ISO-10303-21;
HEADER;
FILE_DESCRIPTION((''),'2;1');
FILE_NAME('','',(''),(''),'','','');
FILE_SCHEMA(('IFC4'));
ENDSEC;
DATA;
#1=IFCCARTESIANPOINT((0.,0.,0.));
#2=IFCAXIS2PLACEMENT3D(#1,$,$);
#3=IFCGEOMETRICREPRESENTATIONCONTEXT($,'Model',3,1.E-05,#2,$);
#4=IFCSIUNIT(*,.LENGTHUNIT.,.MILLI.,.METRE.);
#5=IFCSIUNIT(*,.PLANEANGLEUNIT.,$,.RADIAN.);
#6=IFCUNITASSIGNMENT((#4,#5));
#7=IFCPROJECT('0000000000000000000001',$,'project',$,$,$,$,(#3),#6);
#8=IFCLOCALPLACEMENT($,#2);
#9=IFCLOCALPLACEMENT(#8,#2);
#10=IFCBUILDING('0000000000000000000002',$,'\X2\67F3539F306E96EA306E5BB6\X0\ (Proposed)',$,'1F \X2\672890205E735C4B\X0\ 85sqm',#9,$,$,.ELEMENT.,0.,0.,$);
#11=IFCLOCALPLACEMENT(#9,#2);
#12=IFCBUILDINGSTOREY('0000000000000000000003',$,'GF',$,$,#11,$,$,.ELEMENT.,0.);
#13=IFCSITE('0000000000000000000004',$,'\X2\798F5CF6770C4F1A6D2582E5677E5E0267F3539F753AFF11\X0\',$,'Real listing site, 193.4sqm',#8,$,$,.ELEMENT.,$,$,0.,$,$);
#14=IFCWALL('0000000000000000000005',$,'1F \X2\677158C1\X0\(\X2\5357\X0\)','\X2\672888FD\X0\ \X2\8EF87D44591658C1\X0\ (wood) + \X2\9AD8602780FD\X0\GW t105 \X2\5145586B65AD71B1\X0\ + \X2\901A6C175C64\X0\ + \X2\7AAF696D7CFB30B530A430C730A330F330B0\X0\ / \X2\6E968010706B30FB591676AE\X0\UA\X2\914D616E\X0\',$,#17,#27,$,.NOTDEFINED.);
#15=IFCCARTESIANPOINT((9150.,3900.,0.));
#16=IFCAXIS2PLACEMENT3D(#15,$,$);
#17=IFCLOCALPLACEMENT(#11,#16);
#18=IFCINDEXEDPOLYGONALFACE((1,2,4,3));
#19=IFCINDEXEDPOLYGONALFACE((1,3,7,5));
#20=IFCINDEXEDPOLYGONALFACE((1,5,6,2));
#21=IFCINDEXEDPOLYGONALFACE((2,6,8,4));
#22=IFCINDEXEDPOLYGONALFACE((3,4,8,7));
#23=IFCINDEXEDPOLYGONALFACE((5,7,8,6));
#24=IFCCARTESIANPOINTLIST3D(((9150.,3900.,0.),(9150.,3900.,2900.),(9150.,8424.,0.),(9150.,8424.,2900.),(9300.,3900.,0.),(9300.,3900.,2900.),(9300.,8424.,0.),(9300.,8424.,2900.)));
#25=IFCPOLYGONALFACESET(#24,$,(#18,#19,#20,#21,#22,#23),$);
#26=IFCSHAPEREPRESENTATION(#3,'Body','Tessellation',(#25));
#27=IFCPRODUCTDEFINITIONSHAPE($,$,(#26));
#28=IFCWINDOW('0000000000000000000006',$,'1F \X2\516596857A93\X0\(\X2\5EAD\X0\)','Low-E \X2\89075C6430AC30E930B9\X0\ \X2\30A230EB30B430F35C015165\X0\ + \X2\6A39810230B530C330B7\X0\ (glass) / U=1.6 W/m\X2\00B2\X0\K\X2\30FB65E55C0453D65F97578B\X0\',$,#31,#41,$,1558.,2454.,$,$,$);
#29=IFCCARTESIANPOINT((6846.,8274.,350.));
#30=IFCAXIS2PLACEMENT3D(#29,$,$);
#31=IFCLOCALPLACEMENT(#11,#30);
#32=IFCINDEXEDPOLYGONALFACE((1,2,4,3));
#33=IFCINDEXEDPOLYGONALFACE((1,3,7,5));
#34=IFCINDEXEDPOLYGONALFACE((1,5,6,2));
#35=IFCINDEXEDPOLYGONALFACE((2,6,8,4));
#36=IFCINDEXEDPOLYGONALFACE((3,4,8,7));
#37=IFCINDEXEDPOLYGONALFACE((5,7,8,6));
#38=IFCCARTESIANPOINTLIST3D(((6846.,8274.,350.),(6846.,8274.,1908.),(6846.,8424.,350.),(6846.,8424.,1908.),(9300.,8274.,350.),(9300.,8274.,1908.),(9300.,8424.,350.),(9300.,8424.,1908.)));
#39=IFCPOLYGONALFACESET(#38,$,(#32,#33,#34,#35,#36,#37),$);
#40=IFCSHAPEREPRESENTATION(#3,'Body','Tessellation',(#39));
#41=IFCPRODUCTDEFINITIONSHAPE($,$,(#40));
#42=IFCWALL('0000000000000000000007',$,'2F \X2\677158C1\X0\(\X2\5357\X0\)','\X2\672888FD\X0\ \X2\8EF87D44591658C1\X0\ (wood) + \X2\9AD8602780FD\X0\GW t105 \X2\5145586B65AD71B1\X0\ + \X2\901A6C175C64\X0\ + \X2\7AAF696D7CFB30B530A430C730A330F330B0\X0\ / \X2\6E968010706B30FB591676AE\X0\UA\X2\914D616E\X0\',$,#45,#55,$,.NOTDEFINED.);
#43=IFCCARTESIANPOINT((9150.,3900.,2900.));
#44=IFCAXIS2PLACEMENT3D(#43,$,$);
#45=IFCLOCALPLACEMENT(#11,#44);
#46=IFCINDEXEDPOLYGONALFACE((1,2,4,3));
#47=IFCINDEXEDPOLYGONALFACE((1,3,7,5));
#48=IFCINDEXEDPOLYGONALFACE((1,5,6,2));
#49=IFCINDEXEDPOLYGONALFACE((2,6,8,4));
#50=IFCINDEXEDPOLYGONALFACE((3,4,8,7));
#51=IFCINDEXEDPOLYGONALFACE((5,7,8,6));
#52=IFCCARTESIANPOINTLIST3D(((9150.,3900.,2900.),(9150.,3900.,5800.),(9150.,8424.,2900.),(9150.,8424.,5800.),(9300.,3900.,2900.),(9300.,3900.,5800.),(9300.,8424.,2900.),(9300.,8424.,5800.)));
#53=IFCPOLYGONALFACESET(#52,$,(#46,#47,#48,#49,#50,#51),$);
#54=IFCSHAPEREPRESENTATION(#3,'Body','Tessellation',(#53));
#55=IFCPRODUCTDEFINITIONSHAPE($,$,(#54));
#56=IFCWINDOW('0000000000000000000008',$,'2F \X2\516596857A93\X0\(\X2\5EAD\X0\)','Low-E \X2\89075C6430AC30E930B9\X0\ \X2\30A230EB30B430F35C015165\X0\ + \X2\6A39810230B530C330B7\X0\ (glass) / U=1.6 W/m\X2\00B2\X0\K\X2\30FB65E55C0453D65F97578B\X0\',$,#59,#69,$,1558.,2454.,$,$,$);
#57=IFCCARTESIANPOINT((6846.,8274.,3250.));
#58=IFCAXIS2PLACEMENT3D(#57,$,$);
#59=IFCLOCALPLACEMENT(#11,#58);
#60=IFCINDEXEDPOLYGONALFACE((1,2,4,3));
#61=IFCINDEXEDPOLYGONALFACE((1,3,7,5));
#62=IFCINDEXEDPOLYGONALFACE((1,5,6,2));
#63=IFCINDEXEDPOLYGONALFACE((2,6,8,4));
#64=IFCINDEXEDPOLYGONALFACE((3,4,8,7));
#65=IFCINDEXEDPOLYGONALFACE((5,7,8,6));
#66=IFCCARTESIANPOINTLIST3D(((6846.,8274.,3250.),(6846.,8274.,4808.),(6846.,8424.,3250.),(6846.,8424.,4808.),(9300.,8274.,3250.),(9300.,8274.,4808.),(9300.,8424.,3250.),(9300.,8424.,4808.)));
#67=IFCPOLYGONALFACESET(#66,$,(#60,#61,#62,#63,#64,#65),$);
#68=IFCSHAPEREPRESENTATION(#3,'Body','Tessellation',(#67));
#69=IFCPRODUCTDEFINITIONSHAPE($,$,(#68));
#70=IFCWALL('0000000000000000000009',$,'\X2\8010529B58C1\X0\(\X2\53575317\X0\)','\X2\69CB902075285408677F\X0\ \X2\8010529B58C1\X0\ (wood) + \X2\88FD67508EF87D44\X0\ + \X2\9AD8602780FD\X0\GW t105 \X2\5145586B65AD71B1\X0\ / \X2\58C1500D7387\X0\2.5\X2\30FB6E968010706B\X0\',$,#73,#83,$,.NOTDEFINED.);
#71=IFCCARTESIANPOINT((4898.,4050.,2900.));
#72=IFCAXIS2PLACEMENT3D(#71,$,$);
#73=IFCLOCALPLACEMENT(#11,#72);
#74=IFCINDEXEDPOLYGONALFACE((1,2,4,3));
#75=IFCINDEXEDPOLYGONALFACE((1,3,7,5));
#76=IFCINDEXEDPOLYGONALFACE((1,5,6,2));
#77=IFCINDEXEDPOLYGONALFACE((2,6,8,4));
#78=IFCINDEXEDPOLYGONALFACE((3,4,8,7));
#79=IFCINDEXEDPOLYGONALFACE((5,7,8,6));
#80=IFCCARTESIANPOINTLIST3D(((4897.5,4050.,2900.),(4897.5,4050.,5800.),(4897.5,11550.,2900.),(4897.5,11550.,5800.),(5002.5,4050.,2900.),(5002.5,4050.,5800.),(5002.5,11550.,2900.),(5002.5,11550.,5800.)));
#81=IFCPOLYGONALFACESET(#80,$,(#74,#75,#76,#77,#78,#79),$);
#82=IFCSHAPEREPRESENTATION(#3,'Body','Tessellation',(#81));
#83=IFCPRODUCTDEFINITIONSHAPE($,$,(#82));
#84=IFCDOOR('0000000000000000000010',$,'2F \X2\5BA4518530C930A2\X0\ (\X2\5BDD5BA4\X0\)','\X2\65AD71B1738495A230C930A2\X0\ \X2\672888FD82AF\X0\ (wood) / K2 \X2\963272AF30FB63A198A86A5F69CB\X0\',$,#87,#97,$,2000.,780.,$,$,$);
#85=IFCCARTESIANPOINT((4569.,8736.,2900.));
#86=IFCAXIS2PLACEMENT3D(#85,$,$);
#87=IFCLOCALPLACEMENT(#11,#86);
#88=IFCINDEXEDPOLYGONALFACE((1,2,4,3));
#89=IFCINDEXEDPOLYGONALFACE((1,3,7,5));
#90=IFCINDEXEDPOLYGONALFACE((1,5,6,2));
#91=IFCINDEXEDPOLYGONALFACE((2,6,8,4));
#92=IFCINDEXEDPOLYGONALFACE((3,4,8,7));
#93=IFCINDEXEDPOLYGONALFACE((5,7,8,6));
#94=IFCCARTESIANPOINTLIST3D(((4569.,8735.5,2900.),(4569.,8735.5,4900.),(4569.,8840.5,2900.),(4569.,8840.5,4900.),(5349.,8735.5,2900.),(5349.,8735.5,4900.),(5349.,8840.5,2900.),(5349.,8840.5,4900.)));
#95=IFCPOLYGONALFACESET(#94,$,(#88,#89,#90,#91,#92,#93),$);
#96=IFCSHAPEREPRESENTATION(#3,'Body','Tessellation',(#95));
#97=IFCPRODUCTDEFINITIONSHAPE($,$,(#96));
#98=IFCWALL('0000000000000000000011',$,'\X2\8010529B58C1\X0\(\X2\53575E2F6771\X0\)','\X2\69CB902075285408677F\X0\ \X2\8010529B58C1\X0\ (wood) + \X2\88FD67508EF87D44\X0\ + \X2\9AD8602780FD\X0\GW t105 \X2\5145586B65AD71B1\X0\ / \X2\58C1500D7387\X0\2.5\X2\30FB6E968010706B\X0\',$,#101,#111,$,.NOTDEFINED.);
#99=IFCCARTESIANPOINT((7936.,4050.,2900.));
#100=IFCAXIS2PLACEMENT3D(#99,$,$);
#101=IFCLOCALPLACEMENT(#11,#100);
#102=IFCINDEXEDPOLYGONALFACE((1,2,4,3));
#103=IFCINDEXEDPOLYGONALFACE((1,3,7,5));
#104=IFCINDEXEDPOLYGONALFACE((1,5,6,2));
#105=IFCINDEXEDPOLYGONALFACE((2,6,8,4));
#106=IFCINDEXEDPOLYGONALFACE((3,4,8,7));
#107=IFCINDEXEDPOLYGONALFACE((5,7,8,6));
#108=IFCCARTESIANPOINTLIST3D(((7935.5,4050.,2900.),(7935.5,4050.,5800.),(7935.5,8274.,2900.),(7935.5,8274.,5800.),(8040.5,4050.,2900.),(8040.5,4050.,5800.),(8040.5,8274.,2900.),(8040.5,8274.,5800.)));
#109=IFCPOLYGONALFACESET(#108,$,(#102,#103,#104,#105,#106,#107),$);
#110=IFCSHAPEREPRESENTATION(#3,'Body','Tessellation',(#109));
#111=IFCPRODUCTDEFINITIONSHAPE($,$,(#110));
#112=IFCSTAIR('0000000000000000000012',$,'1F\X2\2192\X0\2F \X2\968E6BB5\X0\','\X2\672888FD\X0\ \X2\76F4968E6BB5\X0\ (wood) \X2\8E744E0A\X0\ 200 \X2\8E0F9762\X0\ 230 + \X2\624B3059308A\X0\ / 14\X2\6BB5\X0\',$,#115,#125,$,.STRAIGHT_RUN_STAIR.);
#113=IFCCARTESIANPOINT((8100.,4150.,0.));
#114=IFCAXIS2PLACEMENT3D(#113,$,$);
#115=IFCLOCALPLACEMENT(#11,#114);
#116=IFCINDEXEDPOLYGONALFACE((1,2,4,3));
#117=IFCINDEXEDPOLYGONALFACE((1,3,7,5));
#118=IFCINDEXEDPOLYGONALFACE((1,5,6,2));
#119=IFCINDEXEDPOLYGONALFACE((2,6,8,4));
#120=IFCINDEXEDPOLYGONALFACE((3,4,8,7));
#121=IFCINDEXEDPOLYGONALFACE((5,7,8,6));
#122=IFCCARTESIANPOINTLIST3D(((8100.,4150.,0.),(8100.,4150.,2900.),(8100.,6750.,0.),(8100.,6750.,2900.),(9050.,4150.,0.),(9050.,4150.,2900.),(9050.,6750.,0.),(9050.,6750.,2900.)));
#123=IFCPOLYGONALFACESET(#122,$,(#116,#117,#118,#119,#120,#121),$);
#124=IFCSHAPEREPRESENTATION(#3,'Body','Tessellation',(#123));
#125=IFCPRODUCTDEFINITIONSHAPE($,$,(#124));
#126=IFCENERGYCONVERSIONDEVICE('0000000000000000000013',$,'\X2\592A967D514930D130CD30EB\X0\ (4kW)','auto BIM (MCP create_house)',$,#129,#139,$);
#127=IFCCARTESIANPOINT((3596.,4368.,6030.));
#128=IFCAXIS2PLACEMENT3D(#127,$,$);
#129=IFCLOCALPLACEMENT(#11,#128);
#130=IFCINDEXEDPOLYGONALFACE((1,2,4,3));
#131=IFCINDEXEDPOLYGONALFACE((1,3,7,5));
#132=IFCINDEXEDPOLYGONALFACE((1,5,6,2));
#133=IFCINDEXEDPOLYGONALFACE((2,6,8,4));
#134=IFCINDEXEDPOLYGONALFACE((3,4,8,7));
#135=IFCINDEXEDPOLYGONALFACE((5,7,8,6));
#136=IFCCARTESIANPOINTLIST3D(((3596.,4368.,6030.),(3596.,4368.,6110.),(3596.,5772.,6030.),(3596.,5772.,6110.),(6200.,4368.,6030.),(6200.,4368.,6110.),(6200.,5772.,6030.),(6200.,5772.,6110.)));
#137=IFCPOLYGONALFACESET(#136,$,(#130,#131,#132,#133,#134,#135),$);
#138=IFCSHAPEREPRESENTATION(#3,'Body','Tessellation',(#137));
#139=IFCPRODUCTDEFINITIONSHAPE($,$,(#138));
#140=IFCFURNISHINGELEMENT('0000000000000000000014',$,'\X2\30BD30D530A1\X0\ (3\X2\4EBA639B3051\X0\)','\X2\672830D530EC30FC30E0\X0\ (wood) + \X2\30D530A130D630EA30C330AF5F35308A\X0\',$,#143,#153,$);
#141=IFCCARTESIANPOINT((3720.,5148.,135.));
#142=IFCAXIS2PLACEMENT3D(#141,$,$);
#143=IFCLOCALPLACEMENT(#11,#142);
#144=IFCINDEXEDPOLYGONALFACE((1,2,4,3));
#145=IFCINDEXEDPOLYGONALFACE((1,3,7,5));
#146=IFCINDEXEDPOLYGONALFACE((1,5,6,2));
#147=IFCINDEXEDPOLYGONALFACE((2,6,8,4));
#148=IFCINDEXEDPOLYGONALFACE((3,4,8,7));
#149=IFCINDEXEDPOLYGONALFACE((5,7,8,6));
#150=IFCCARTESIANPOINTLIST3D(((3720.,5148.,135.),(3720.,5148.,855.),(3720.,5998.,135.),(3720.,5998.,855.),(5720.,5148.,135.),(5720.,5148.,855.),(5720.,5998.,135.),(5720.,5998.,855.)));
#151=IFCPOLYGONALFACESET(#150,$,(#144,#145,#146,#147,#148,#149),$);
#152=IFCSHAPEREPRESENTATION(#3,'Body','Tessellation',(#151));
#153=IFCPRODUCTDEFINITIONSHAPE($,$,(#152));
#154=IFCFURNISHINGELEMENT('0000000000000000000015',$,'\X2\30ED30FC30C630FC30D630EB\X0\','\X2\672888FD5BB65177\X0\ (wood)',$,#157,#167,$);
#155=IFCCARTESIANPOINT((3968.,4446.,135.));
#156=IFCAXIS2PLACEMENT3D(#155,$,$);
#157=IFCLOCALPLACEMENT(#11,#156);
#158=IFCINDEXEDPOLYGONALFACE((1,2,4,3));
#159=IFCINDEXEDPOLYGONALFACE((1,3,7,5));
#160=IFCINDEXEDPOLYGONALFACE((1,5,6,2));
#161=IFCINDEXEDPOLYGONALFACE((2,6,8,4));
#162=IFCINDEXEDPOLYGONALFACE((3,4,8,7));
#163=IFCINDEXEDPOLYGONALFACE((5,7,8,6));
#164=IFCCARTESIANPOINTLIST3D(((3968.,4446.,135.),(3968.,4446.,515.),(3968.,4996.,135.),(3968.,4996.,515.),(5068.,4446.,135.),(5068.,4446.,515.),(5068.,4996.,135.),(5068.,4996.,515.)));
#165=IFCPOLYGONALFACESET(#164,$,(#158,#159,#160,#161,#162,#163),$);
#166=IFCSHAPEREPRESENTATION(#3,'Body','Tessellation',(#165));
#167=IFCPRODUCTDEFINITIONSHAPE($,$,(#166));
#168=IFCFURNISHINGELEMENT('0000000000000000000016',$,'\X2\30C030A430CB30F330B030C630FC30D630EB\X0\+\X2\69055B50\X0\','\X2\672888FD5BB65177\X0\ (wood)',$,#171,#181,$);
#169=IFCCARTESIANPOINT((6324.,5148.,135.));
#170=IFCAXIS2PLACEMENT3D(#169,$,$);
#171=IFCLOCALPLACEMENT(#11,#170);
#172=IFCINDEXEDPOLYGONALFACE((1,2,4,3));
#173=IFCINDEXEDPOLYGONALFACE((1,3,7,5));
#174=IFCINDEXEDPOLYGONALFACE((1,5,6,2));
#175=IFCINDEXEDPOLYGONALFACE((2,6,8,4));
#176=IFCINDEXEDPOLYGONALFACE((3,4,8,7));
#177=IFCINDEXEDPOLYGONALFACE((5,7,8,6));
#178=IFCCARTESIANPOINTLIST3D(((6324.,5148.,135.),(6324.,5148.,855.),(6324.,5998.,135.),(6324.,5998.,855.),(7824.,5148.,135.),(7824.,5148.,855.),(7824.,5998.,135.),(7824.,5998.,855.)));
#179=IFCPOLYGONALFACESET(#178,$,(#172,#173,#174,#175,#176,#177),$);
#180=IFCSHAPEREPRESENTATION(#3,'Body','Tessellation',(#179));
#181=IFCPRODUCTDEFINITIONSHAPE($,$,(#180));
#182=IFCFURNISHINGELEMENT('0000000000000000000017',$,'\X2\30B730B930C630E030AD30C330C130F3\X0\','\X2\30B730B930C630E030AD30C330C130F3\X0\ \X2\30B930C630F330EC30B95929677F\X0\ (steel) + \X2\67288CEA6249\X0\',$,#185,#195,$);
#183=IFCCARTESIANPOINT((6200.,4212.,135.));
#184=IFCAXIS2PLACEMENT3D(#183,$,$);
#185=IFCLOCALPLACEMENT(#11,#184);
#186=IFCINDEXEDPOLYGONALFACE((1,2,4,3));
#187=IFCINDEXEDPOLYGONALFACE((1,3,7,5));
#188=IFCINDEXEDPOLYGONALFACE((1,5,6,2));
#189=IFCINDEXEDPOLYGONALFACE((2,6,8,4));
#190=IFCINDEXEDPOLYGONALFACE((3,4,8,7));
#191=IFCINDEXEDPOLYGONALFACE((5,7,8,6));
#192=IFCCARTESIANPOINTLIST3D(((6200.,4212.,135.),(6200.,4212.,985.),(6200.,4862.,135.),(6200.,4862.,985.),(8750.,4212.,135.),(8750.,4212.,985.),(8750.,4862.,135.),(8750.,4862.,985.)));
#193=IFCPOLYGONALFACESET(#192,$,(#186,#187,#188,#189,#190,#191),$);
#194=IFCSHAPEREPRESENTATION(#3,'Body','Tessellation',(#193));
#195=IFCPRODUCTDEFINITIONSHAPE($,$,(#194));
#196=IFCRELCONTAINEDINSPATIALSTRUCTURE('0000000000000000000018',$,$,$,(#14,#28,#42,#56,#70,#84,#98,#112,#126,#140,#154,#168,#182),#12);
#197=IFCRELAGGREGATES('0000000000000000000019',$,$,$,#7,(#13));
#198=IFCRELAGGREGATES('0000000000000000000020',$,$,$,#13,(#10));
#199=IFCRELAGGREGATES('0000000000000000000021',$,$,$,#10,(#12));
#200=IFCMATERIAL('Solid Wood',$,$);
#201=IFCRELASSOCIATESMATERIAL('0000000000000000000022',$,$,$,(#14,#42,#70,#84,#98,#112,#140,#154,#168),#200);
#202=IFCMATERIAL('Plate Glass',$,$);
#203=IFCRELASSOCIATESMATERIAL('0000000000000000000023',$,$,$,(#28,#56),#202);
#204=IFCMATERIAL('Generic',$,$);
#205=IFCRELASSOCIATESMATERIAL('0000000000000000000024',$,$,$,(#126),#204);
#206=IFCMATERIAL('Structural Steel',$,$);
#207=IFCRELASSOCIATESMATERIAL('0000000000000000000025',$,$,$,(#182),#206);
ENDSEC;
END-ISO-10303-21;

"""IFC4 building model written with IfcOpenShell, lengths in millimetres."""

from ifc_helpers import new_model, si_unit, frame, frame_2d, origin, place, context, project, spatial, rectangle, extrude, material, element, fill, save


model = new_model("IFC4")

# Units and contexts
model_context = context("Model", 3, precision=1e-05, world=origin())
ifc_project = project(units=[si_unit("LENGTHUNIT", "METRE", prefix="MILLI"), si_unit("PLANEANGLEUNIT", "RADIAN")], contexts=[model_context])

# Site, building, storey
site_placement = place(None, origin())
site = spatial("IfcSite", under=ifc_project, at=site_placement, Name="福島県会津若松市柳原町１", ObjectType="Real listing site, 193.4sqm", CompositionType="ELEMENT", RefElevation=0.0)
building_placement = place(site_placement, origin())
building = spatial("IfcBuilding", under=site, at=building_placement, Name="柳原の雪の家 (Proposed)", ObjectType="1F 木造平屋 85sqm", CompositionType="ELEMENT", ElevationOfRefHeight=0.0, ElevationOfTerrain=0.0)
storey_placement = place(building_placement, origin())
storey = spatial("IfcBuildingStorey", under=building, at=storey_placement, Name="GF", CompositionType="ELEMENT", Elevation=0.0)

# Wall, opening, window
ifc_material_1 = material(Name="Solid Wood")
wall_1_placement = place(storey_placement, frame((9150.0, 3900.0, 0.0)))
wall_1 = element("IfcWall", 1, at=wall_1_placement, inside=storey, material=ifc_material_1, Name="1F 東壁(南)", Description="木製 軸組外壁 (wood) + 高性能GW t105 充填断熱 + 通気層 + 窯業系サイディング / 準耐火・外皮UA配慮", PredefinedType="NOTDEFINED", context=model_context, shape_type="SweptSolid", body=[
    extrude(rectangle(XDim=150.0, YDim=4524.0, at=frame_2d((75.0, 2262.0))), frame((9150.0, 3900.0, 0.0)), (0.0, 0.0, 1.0), 2900.0),
])
opening_1_placement = place(storey_placement, frame((6846.0, 8274.0, 350.0)))
opening_1 = element("IfcOpeningElement", 2, at=opening_1_placement, cuts=wall_1, PredefinedType="NOTDEFINED", context=model_context, shape_type="SweptSolid", body=[
    extrude(rectangle(XDim=2454.0, YDim=150.0, at=frame_2d((1227.0, 75.0))), frame((6846.0, 8274.0, 350.0)), (0.0, 0.0, 1.0), 1558.0),
])
ifc_material_2 = material(Name="Plate Glass")
window_1_placement = place(storey_placement, frame((6846.0, 8274.0, 350.0)))
window_1 = element("IfcWindow", 3, at=window_1_placement, inside=storey, material=ifc_material_2, Name="1F 入隅窓(庭)", Description="Low-E 複層ガラス アルゴン封入 + 樹脂サッシ (glass) / U=1.6 W/m²K・日射取得型", OverallHeight=1558.0, OverallWidth=2454.0, context=model_context, shape_type="SweptSolid", body=[
    extrude(rectangle(XDim=2454.0, YDim=150.0, at=frame_2d((1227.0, 75.0))), frame((6846.0, 8274.0, 350.0)), (0.0, 0.0, 1.0), 1558.0),
])
fill(opening_1, window_1)

# Wall, opening, window
wall_2_placement = place(storey_placement, frame((9150.0, 3900.0, 2900.0)))
wall_2 = element("IfcWall", 4, at=wall_2_placement, inside=storey, material=ifc_material_1, Name="2F 東壁(南)", Description="木製 軸組外壁 (wood) + 高性能GW t105 充填断熱 + 通気層 + 窯業系サイディング / 準耐火・外皮UA配慮", PredefinedType="NOTDEFINED", context=model_context, shape_type="SweptSolid", body=[
    extrude(rectangle(XDim=150.0, YDim=4524.0, at=frame_2d((75.0, 2262.0))), frame((9150.0, 3900.0, 2900.0)), (0.0, 0.0, 1.0), 2900.0),
])
opening_2_placement = place(storey_placement, frame((6846.0, 8274.0, 3250.0)))
opening_2 = element("IfcOpeningElement", 5, at=opening_2_placement, cuts=wall_2, PredefinedType="NOTDEFINED", context=model_context, shape_type="SweptSolid", body=[
    extrude(rectangle(XDim=2454.0, YDim=150.0, at=frame_2d((1227.0, 75.0))), frame((6846.0, 8274.0, 3250.0)), (0.0, 0.0, 1.0), 1558.0),
])
window_2_placement = place(storey_placement, frame((6846.0, 8274.0, 3250.0)))
window_2 = element("IfcWindow", 6, at=window_2_placement, inside=storey, material=ifc_material_2, Name="2F 入隅窓(庭)", Description="Low-E 複層ガラス アルゴン封入 + 樹脂サッシ (glass) / U=1.6 W/m²K・日射取得型", OverallHeight=1558.0, OverallWidth=2454.0, context=model_context, shape_type="SweptSolid", body=[
    extrude(rectangle(XDim=2454.0, YDim=150.0, at=frame_2d((1227.0, 75.0))), frame((6846.0, 8274.0, 3250.0)), (0.0, 0.0, 1.0), 1558.0),
])
fill(opening_2, window_2)

# Wall, opening, door
wall_3_placement = place(storey_placement, frame((4898.0, 4050.0, 2900.0)))
wall_3 = element("IfcWall", 7, at=wall_3_placement, inside=storey, material=ifc_material_1, Name="耐力壁(南北)", Description="構造用合板 耐力壁 (wood) + 製材軸組 + 高性能GW t105 充填断熱 / 壁倍率2.5・準耐火", PredefinedType="NOTDEFINED", context=model_context, shape_type="SweptSolid", body=[
    extrude(rectangle(XDim=105.0, YDim=7500.0, at=frame_2d((52.0, 3750.0))), frame((4898.0, 4050.0, 2900.0)), (0.0, 0.0, 1.0), 2900.0),
])
opening_3_placement = place(storey_placement, frame((4569.0, 8736.0, 2900.0)))
opening_3 = element("IfcOpeningElement", 8, at=opening_3_placement, cuts=wall_3, PredefinedType="NOTDEFINED", context=model_context, shape_type="SweptSolid", body=[
    extrude(rectangle(XDim=780.0, YDim=105.0, at=frame_2d((390.0, 52.0))), frame((4569.0, 8736.0, 2900.0)), (0.0, 0.0, 1.0), 2000.0),
])
door_1_placement = place(storey_placement, frame((4569.0, 8736.0, 2900.0)))
door_1 = element("IfcDoor", 9, at=door_1_placement, inside=storey, material=ifc_material_1, Name="2F 室内ドア (寝室)", Description="断熱玄関ドア 木製芯 (wood) / K2 防犯・採風機構", OverallHeight=2000.0, OverallWidth=780.0, context=model_context, shape_type="SweptSolid", body=[
    extrude(rectangle(XDim=780.0, YDim=105.0, at=frame_2d((390.0, 52.0))), frame((4569.0, 8736.0, 2900.0)), (0.0, 0.0, 1.0), 2000.0),
])
fill(opening_3, door_1)

# Wall
wall_4_placement = place(storey_placement, frame((7936.0, 4050.0, 2900.0)))
element("IfcWall", 10, at=wall_4_placement, inside=storey, material=ifc_material_1, Name="耐力壁(南帯東)", Description="構造用合板 耐力壁 (wood) + 製材軸組 + 高性能GW t105 充填断熱 / 壁倍率2.5・準耐火", PredefinedType="NOTDEFINED", context=model_context, shape_type="SweptSolid", body=[
    extrude(rectangle(XDim=105.0, YDim=4224.0, at=frame_2d((52.0, 2112.0))), frame((7936.0, 4050.0, 2900.0)), (0.0, 0.0, 1.0), 2900.0),
])

# Stair
stair_placement = place(storey_placement, frame((8100.0, 4150.0, 0.0)))
element("IfcStair", 11, at=stair_placement, inside=storey, material=ifc_material_1, Name="1F→2F 階段", Description="木製 直階段 (wood) 蹴上 200 踏面 230 + 手すり / 14段", PredefinedType="STRAIGHT_RUN_STAIR", context=model_context, shape_type="SweptSolid", body=[
    extrude(rectangle(XDim=950.0, YDim=2600.0, at=frame_2d((475.0, 1300.0))), frame((8100.0, 4150.0, 0.0)), (0.0, 0.0, 1.0), 2900.0),
])

# Energy conversion device
ifc_material_3 = material(Name="Generic")
energy_conversion_device_placement = place(storey_placement, frame((3596.0, 4368.0, 6030.0)))
element("IfcEnergyConversionDevice", 12, at=energy_conversion_device_placement, inside=storey, material=ifc_material_3, Name="太陽光パネル (4kW)", Description="auto BIM (MCP create_house)", context=model_context, shape_type="SweptSolid", body=[
    extrude(rectangle(XDim=2604.0, YDim=1404.0, at=frame_2d((1302.0, 702.0))), frame((3596.0, 4368.0, 6030.0)), (0.0, 0.0, 1.0), 80.0),
])

# Furnishing elements
furnishing_1_placement = place(storey_placement, frame((3720.0, 5148.0, 135.0)))
element("IfcFurnishingElement", 13, at=furnishing_1_placement, inside=storey, material=ifc_material_1, Name="ソファ (3人掛け)", Description="木フレーム (wood) + ファブリック張り", context=model_context, shape_type="SweptSolid", body=[
    extrude(rectangle(XDim=2000.0, YDim=850.0, at=frame_2d((1000.0, 425.0))), frame((3720.0, 5148.0, 135.0)), (0.0, 0.0, 1.0), 720.0),
])
furnishing_2_placement = place(storey_placement, frame((3968.0, 4446.0, 135.0)))
element("IfcFurnishingElement", 14, at=furnishing_2_placement, inside=storey, material=ifc_material_1, Name="ローテーブル", Description="木製家具 (wood)", context=model_context, shape_type="SweptSolid", body=[
    extrude(rectangle(XDim=1100.0, YDim=550.0, at=frame_2d((550.0, 275.0))), frame((3968.0, 4446.0, 135.0)), (0.0, 0.0, 1.0), 380.0),
])
furnishing_3_placement = place(storey_placement, frame((6324.0, 5148.0, 135.0)))
element("IfcFurnishingElement", 15, at=furnishing_3_placement, inside=storey, material=ifc_material_1, Name="ダイニングテーブル+椅子", Description="木製家具 (wood)", context=model_context, shape_type="SweptSolid", body=[
    extrude(rectangle(XDim=1500.0, YDim=850.0, at=frame_2d((750.0, 425.0))), frame((6324.0, 5148.0, 135.0)), (0.0, 0.0, 1.0), 720.0),
])
ifc_material_4 = material(Name="Structural Steel")
furnishing_4_placement = place(storey_placement, frame((6200.0, 4212.0, 135.0)))
element("IfcFurnishingElement", 16, at=furnishing_4_placement, inside=storey, material=ifc_material_4, Name="システムキッチン", Description="システムキッチン ステンレス天板 (steel) + 木質扉", context=model_context, shape_type="SweptSolid", body=[
    extrude(rectangle(XDim=2550.0, YDim=650.0, at=frame_2d((1275.0, 325.0))), frame((6200.0, 4212.0, 135.0)), (0.0, 0.0, 1.0), 850.0),
])

save(model, "model.ifc")
